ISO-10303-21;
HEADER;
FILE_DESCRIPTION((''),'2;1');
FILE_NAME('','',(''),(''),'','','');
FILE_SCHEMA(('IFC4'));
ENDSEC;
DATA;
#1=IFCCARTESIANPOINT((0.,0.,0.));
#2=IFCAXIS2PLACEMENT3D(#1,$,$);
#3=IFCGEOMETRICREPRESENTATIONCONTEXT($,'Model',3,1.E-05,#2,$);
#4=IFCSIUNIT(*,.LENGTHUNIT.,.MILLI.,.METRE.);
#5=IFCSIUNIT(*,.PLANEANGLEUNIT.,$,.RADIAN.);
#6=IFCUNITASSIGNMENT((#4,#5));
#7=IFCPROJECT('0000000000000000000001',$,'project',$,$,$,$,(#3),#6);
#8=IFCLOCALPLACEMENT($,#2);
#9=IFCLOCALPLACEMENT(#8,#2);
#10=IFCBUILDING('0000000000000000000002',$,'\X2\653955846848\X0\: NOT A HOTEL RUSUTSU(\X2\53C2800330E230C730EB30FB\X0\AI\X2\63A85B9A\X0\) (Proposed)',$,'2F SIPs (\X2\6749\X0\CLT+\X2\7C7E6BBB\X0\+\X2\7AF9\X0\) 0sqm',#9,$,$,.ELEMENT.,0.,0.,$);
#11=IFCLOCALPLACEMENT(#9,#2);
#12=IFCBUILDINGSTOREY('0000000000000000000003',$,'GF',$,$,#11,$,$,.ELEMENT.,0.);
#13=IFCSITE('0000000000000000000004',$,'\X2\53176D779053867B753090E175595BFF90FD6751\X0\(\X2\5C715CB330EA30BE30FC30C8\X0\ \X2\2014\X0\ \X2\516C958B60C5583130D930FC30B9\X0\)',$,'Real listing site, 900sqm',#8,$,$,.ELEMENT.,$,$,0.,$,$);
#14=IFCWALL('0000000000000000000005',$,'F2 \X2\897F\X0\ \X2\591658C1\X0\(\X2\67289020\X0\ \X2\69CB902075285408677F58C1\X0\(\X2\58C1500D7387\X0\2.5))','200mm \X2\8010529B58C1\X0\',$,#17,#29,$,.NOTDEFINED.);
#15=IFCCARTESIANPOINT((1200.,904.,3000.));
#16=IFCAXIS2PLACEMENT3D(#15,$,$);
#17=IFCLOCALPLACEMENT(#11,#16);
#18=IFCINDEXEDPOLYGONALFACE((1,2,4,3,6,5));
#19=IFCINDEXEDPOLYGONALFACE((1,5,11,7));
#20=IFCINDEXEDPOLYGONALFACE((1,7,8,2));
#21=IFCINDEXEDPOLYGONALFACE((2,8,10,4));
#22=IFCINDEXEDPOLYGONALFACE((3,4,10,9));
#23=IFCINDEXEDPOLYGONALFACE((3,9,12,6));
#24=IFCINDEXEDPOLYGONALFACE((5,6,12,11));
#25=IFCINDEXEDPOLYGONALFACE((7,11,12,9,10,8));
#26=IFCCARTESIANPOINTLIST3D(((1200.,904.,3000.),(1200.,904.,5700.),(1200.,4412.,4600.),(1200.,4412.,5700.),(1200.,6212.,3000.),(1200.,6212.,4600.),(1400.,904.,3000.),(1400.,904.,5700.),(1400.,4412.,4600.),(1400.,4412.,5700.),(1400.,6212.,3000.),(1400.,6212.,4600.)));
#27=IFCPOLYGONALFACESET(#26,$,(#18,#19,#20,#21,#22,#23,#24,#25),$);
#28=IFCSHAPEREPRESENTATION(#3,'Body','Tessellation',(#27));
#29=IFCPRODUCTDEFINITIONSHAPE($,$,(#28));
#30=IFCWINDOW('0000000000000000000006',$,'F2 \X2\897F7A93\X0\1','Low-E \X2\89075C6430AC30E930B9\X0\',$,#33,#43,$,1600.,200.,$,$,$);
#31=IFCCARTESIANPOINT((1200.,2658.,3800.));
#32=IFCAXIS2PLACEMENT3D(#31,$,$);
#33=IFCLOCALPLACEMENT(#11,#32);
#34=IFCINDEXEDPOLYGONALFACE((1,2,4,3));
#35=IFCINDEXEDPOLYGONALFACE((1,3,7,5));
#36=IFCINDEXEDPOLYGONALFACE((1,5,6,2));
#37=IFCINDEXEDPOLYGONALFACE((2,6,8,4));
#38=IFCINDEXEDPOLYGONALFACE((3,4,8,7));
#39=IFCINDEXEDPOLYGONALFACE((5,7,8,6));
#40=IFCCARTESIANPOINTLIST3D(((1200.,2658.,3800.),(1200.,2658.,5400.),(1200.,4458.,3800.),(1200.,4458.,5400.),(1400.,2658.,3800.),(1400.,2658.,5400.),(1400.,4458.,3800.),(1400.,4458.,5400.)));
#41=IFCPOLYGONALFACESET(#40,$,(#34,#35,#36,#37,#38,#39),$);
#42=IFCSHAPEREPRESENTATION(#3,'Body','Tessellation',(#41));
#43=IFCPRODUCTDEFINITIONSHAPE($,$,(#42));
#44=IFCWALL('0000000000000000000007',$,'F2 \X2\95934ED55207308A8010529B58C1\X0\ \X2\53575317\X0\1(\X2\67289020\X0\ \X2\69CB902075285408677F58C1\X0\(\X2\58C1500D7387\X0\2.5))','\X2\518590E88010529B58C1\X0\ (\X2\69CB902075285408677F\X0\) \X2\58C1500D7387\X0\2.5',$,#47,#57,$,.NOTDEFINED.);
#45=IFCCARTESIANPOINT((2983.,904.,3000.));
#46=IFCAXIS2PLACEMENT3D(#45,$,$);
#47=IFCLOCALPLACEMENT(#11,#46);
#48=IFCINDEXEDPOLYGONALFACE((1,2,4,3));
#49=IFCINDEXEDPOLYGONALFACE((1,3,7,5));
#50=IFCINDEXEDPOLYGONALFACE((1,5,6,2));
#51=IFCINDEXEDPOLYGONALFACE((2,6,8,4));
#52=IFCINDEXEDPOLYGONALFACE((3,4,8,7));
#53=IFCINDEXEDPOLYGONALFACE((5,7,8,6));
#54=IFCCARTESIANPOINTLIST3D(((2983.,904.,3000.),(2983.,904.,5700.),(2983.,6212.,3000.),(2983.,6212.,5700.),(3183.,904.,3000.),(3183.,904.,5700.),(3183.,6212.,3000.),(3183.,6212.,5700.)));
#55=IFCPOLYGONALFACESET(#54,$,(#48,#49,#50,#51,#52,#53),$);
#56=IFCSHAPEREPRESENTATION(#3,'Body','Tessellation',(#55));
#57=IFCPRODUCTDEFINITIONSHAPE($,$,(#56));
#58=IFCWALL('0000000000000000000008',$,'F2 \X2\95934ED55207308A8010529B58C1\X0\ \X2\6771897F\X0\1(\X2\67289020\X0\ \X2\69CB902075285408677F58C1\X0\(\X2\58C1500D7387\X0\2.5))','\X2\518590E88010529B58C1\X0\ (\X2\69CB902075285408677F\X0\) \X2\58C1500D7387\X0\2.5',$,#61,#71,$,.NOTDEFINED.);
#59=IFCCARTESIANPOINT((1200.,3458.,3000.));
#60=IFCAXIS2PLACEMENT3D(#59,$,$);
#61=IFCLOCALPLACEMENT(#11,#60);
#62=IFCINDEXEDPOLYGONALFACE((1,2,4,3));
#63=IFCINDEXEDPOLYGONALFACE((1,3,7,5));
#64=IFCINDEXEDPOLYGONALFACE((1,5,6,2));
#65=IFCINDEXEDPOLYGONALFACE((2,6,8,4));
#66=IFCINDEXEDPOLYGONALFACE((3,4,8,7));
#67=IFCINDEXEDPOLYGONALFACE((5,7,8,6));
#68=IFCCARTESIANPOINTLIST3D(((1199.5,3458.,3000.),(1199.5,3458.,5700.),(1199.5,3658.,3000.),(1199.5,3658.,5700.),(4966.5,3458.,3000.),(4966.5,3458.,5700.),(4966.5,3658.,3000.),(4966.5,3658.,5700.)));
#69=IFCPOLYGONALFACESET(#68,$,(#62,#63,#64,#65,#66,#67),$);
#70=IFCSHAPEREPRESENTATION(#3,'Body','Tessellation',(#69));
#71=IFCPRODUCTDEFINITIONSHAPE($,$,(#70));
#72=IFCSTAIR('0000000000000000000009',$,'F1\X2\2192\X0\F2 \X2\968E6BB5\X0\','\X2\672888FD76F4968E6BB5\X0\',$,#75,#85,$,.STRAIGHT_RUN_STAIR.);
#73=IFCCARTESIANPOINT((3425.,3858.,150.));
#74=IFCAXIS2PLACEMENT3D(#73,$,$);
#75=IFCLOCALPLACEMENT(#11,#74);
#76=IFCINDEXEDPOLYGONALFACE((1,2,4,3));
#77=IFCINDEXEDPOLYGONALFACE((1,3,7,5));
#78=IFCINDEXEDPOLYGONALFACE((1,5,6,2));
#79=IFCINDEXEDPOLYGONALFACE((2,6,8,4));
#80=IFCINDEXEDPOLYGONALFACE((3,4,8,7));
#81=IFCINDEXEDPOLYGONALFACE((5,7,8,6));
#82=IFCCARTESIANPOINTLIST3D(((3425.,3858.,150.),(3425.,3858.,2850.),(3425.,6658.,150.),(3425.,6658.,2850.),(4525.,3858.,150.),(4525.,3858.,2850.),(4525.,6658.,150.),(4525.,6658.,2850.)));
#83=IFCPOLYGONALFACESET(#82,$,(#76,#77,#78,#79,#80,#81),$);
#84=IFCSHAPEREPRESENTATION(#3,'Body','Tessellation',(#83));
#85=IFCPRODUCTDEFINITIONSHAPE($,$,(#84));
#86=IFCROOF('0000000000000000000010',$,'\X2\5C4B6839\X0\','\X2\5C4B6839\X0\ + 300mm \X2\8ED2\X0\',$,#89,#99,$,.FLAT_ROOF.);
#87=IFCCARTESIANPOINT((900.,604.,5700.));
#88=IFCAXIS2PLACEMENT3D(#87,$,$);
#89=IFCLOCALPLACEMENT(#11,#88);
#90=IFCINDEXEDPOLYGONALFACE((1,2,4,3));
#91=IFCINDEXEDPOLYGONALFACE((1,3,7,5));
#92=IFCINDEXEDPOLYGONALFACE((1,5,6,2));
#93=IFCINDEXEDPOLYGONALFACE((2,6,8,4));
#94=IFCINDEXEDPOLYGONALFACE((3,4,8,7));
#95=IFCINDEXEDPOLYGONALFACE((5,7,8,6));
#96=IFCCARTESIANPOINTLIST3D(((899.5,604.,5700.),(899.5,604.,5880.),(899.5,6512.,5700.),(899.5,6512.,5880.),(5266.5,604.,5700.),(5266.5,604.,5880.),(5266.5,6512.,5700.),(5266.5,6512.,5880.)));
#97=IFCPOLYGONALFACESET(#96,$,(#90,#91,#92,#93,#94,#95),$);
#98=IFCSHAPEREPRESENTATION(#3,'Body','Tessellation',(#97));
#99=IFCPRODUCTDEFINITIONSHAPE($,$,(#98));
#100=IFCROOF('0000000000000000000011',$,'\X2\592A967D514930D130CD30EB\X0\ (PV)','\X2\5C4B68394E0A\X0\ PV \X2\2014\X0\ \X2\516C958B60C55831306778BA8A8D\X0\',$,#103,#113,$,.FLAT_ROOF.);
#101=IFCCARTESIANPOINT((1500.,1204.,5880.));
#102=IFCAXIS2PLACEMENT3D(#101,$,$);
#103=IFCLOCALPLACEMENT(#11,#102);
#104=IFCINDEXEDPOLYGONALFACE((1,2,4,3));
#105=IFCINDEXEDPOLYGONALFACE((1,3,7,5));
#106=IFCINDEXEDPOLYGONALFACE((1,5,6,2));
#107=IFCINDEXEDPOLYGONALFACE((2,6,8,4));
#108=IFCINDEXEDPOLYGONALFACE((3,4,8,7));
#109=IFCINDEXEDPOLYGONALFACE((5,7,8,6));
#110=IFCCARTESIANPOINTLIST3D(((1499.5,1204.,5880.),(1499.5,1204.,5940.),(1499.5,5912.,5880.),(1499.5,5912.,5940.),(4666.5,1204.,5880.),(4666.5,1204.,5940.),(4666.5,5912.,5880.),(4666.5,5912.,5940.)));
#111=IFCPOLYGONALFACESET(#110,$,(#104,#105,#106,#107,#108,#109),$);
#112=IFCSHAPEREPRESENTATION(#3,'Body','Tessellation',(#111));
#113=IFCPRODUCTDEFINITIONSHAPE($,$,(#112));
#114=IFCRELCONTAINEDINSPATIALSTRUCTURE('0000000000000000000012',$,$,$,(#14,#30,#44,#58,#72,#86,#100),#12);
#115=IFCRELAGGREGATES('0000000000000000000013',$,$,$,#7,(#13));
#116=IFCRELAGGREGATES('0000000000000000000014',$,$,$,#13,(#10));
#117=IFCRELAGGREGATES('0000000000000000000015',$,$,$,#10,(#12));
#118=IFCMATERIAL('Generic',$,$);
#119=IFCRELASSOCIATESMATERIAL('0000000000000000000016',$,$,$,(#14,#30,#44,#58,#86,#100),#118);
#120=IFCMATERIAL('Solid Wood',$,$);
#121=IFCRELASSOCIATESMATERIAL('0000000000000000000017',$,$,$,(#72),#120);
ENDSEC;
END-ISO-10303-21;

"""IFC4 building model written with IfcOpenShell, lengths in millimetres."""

from ifc_helpers import new_model, si_unit, frame, frame_2d, origin, place, context, project, spatial, rectangle, extrude, material, element, fill, save


model = new_model("IFC4")

# Units and contexts
model_context = context("Model", 3, precision=1e-05, world=origin())
ifc_project = project(units=[si_unit("LENGTHUNIT", "METRE", prefix="MILLI"), si_unit("PLANEANGLEUNIT", "RADIAN")], contexts=[model_context])

# Site, building, storey
site_placement = place(None, origin())
site = spatial("IfcSite", under=ifc_project, at=site_placement, Name="北海道虻田郡留寿都村(山岳リゾート — 公開情報ベース)", ObjectType="Real listing site, 900sqm", CompositionType="ELEMENT", RefElevation=0.0)
building_placement = place(site_placement, origin())
building = spatial("IfcBuilding", under=site, at=building_placement, Name="改善案: NOT A HOTEL RUSUTSU(参考モデル・AI推定) (Proposed)", ObjectType="2F SIPs (杉CLT+籾殻+竹) 0sqm", CompositionType="ELEMENT", ElevationOfRefHeight=0.0, ElevationOfTerrain=0.0)
storey_placement = place(building_placement, origin())
storey = spatial("IfcBuildingStorey", under=building, at=storey_placement, Name="GF", CompositionType="ELEMENT", Elevation=0.0)

# Shared definitions
ifc_material_1 = material(Name="Generic")

# Shared definitions
ifc_material_2 = material(Name="Solid Wood")

# Wall, opening, window
wall_1_placement = place(storey_placement, frame((1200.0, 904.0, 3000.0)))
wall_1 = element("IfcWall", 1, at=wall_1_placement, inside=storey, material=ifc_material_1, Name="F2 西 外壁(木造 構造用合板壁(壁倍率2.5))", Description="200mm 耐力壁", PredefinedType="NOTDEFINED", context=model_context, shape_type="SweptSolid", body=[
    extrude(rectangle(XDim=200.0, YDim=5308.0, at=frame_2d((100.0, 2654.0))), frame((1200.0, 904.0, 3000.0)), (0.0, 0.0, 1.0), 2700.0),
])
opening_1_placement = place(storey_placement, frame((1200.0, 2658.0, 3800.0)))
opening_1 = element("IfcOpeningElement", 2, at=opening_1_placement, cuts=wall_1, PredefinedType="NOTDEFINED", context=model_context, shape_type="SweptSolid", body=[
    extrude(rectangle(XDim=200.0, YDim=1800.0, at=frame_2d((100.0, 900.0))), frame((1200.0, 2658.0, 3800.0)), (0.0, 0.0, 1.0), 1600.0),
])
window_1_placement = place(storey_placement, frame((1200.0, 2658.0, 3800.0)))
window_1 = element("IfcWindow", 3, at=window_1_placement, inside=storey, material=ifc_material_1, Name="F2 西窓1", Description="Low-E 複層ガラス", OverallHeight=1600.0, OverallWidth=200.0, context=model_context, shape_type="SweptSolid", body=[
    extrude(rectangle(XDim=200.0, YDim=1800.0, at=frame_2d((100.0, 900.0))), frame((1200.0, 2658.0, 3800.0)), (0.0, 0.0, 1.0), 1600.0),
])
fill(opening_1, window_1)

# Walls
wall_2_placement = place(storey_placement, frame((2983.0, 904.0, 3000.0)))
element("IfcWall", 4, at=wall_2_placement, inside=storey, material=ifc_material_1, Name="F2 間仕切り耐力壁 南北1(木造 構造用合板壁(壁倍率2.5))", Description="内部耐力壁 (構造用合板) 壁倍率2.5", PredefinedType="NOTDEFINED", context=model_context, shape_type="SweptSolid", body=[
    extrude(rectangle(XDim=200.0, YDim=5308.0, at=frame_2d((100.0, 2654.0))), frame((2983.0, 904.0, 3000.0)), (0.0, 0.0, 1.0), 2700.0),
])
wall_3_placement = place(storey_placement, frame((1200.0, 3458.0, 3000.0)))
element("IfcWall", 5, at=wall_3_placement, inside=storey, material=ifc_material_1, Name="F2 間仕切り耐力壁 東西1(木造 構造用合板壁(壁倍率2.5))", Description="内部耐力壁 (構造用合板) 壁倍率2.5", PredefinedType="NOTDEFINED", context=model_context, shape_type="SweptSolid", body=[
    extrude(rectangle(XDim=3767.0, YDim=200.0, at=frame_2d((1883.0, 100.0))), frame((1200.0, 3458.0, 3000.0)), (0.0, 0.0, 1.0), 2700.0),
])

# Stair
stair_placement = place(storey_placement, frame((3425.0, 3858.0, 150.0)))
element("IfcStair", 6, at=stair_placement, inside=storey, material=ifc_material_2, Name="F1→F2 階段", Description="木製直階段", PredefinedType="STRAIGHT_RUN_STAIR", context=model_context, shape_type="SweptSolid", body=[
    extrude(rectangle(XDim=1100.0, YDim=2800.0, at=frame_2d((550.0, 1400.0))), frame((3425.0, 3858.0, 150.0)), (0.0, 0.0, 1.0), 2700.0),
])

# Roofs
roof_1_placement = place(storey_placement, frame((900.0, 604.0, 5700.0)))
element("IfcRoof", 7, at=roof_1_placement, inside=storey, material=ifc_material_1, Name="屋根", Description="屋根 + 300mm 軒", PredefinedType="FLAT_ROOF", context=model_context, shape_type="SweptSolid", body=[
    extrude(rectangle(XDim=4367.0, YDim=5908.0, at=frame_2d((2183.0, 2954.0))), frame((900.0, 604.0, 5700.0)), (0.0, 0.0, 1.0), 180.0),
])
roof_2_placement = place(storey_placement, frame((1500.0, 1204.0, 5880.0)))
element("IfcRoof", 8, at=roof_2_placement, inside=storey, material=ifc_material_1, Name="太陽光パネル (PV)", Description="屋根上 PV — 公開情報で確認", PredefinedType="FLAT_ROOF", context=model_context, shape_type="SweptSolid", body=[
    extrude(rectangle(XDim=3167.0, YDim=4708.0, at=frame_2d((1583.0, 2354.0))), frame((1500.0, 1204.0, 5880.0)), (0.0, 0.0, 1.0), 60.0),
])

save(model, "model.ifc")
